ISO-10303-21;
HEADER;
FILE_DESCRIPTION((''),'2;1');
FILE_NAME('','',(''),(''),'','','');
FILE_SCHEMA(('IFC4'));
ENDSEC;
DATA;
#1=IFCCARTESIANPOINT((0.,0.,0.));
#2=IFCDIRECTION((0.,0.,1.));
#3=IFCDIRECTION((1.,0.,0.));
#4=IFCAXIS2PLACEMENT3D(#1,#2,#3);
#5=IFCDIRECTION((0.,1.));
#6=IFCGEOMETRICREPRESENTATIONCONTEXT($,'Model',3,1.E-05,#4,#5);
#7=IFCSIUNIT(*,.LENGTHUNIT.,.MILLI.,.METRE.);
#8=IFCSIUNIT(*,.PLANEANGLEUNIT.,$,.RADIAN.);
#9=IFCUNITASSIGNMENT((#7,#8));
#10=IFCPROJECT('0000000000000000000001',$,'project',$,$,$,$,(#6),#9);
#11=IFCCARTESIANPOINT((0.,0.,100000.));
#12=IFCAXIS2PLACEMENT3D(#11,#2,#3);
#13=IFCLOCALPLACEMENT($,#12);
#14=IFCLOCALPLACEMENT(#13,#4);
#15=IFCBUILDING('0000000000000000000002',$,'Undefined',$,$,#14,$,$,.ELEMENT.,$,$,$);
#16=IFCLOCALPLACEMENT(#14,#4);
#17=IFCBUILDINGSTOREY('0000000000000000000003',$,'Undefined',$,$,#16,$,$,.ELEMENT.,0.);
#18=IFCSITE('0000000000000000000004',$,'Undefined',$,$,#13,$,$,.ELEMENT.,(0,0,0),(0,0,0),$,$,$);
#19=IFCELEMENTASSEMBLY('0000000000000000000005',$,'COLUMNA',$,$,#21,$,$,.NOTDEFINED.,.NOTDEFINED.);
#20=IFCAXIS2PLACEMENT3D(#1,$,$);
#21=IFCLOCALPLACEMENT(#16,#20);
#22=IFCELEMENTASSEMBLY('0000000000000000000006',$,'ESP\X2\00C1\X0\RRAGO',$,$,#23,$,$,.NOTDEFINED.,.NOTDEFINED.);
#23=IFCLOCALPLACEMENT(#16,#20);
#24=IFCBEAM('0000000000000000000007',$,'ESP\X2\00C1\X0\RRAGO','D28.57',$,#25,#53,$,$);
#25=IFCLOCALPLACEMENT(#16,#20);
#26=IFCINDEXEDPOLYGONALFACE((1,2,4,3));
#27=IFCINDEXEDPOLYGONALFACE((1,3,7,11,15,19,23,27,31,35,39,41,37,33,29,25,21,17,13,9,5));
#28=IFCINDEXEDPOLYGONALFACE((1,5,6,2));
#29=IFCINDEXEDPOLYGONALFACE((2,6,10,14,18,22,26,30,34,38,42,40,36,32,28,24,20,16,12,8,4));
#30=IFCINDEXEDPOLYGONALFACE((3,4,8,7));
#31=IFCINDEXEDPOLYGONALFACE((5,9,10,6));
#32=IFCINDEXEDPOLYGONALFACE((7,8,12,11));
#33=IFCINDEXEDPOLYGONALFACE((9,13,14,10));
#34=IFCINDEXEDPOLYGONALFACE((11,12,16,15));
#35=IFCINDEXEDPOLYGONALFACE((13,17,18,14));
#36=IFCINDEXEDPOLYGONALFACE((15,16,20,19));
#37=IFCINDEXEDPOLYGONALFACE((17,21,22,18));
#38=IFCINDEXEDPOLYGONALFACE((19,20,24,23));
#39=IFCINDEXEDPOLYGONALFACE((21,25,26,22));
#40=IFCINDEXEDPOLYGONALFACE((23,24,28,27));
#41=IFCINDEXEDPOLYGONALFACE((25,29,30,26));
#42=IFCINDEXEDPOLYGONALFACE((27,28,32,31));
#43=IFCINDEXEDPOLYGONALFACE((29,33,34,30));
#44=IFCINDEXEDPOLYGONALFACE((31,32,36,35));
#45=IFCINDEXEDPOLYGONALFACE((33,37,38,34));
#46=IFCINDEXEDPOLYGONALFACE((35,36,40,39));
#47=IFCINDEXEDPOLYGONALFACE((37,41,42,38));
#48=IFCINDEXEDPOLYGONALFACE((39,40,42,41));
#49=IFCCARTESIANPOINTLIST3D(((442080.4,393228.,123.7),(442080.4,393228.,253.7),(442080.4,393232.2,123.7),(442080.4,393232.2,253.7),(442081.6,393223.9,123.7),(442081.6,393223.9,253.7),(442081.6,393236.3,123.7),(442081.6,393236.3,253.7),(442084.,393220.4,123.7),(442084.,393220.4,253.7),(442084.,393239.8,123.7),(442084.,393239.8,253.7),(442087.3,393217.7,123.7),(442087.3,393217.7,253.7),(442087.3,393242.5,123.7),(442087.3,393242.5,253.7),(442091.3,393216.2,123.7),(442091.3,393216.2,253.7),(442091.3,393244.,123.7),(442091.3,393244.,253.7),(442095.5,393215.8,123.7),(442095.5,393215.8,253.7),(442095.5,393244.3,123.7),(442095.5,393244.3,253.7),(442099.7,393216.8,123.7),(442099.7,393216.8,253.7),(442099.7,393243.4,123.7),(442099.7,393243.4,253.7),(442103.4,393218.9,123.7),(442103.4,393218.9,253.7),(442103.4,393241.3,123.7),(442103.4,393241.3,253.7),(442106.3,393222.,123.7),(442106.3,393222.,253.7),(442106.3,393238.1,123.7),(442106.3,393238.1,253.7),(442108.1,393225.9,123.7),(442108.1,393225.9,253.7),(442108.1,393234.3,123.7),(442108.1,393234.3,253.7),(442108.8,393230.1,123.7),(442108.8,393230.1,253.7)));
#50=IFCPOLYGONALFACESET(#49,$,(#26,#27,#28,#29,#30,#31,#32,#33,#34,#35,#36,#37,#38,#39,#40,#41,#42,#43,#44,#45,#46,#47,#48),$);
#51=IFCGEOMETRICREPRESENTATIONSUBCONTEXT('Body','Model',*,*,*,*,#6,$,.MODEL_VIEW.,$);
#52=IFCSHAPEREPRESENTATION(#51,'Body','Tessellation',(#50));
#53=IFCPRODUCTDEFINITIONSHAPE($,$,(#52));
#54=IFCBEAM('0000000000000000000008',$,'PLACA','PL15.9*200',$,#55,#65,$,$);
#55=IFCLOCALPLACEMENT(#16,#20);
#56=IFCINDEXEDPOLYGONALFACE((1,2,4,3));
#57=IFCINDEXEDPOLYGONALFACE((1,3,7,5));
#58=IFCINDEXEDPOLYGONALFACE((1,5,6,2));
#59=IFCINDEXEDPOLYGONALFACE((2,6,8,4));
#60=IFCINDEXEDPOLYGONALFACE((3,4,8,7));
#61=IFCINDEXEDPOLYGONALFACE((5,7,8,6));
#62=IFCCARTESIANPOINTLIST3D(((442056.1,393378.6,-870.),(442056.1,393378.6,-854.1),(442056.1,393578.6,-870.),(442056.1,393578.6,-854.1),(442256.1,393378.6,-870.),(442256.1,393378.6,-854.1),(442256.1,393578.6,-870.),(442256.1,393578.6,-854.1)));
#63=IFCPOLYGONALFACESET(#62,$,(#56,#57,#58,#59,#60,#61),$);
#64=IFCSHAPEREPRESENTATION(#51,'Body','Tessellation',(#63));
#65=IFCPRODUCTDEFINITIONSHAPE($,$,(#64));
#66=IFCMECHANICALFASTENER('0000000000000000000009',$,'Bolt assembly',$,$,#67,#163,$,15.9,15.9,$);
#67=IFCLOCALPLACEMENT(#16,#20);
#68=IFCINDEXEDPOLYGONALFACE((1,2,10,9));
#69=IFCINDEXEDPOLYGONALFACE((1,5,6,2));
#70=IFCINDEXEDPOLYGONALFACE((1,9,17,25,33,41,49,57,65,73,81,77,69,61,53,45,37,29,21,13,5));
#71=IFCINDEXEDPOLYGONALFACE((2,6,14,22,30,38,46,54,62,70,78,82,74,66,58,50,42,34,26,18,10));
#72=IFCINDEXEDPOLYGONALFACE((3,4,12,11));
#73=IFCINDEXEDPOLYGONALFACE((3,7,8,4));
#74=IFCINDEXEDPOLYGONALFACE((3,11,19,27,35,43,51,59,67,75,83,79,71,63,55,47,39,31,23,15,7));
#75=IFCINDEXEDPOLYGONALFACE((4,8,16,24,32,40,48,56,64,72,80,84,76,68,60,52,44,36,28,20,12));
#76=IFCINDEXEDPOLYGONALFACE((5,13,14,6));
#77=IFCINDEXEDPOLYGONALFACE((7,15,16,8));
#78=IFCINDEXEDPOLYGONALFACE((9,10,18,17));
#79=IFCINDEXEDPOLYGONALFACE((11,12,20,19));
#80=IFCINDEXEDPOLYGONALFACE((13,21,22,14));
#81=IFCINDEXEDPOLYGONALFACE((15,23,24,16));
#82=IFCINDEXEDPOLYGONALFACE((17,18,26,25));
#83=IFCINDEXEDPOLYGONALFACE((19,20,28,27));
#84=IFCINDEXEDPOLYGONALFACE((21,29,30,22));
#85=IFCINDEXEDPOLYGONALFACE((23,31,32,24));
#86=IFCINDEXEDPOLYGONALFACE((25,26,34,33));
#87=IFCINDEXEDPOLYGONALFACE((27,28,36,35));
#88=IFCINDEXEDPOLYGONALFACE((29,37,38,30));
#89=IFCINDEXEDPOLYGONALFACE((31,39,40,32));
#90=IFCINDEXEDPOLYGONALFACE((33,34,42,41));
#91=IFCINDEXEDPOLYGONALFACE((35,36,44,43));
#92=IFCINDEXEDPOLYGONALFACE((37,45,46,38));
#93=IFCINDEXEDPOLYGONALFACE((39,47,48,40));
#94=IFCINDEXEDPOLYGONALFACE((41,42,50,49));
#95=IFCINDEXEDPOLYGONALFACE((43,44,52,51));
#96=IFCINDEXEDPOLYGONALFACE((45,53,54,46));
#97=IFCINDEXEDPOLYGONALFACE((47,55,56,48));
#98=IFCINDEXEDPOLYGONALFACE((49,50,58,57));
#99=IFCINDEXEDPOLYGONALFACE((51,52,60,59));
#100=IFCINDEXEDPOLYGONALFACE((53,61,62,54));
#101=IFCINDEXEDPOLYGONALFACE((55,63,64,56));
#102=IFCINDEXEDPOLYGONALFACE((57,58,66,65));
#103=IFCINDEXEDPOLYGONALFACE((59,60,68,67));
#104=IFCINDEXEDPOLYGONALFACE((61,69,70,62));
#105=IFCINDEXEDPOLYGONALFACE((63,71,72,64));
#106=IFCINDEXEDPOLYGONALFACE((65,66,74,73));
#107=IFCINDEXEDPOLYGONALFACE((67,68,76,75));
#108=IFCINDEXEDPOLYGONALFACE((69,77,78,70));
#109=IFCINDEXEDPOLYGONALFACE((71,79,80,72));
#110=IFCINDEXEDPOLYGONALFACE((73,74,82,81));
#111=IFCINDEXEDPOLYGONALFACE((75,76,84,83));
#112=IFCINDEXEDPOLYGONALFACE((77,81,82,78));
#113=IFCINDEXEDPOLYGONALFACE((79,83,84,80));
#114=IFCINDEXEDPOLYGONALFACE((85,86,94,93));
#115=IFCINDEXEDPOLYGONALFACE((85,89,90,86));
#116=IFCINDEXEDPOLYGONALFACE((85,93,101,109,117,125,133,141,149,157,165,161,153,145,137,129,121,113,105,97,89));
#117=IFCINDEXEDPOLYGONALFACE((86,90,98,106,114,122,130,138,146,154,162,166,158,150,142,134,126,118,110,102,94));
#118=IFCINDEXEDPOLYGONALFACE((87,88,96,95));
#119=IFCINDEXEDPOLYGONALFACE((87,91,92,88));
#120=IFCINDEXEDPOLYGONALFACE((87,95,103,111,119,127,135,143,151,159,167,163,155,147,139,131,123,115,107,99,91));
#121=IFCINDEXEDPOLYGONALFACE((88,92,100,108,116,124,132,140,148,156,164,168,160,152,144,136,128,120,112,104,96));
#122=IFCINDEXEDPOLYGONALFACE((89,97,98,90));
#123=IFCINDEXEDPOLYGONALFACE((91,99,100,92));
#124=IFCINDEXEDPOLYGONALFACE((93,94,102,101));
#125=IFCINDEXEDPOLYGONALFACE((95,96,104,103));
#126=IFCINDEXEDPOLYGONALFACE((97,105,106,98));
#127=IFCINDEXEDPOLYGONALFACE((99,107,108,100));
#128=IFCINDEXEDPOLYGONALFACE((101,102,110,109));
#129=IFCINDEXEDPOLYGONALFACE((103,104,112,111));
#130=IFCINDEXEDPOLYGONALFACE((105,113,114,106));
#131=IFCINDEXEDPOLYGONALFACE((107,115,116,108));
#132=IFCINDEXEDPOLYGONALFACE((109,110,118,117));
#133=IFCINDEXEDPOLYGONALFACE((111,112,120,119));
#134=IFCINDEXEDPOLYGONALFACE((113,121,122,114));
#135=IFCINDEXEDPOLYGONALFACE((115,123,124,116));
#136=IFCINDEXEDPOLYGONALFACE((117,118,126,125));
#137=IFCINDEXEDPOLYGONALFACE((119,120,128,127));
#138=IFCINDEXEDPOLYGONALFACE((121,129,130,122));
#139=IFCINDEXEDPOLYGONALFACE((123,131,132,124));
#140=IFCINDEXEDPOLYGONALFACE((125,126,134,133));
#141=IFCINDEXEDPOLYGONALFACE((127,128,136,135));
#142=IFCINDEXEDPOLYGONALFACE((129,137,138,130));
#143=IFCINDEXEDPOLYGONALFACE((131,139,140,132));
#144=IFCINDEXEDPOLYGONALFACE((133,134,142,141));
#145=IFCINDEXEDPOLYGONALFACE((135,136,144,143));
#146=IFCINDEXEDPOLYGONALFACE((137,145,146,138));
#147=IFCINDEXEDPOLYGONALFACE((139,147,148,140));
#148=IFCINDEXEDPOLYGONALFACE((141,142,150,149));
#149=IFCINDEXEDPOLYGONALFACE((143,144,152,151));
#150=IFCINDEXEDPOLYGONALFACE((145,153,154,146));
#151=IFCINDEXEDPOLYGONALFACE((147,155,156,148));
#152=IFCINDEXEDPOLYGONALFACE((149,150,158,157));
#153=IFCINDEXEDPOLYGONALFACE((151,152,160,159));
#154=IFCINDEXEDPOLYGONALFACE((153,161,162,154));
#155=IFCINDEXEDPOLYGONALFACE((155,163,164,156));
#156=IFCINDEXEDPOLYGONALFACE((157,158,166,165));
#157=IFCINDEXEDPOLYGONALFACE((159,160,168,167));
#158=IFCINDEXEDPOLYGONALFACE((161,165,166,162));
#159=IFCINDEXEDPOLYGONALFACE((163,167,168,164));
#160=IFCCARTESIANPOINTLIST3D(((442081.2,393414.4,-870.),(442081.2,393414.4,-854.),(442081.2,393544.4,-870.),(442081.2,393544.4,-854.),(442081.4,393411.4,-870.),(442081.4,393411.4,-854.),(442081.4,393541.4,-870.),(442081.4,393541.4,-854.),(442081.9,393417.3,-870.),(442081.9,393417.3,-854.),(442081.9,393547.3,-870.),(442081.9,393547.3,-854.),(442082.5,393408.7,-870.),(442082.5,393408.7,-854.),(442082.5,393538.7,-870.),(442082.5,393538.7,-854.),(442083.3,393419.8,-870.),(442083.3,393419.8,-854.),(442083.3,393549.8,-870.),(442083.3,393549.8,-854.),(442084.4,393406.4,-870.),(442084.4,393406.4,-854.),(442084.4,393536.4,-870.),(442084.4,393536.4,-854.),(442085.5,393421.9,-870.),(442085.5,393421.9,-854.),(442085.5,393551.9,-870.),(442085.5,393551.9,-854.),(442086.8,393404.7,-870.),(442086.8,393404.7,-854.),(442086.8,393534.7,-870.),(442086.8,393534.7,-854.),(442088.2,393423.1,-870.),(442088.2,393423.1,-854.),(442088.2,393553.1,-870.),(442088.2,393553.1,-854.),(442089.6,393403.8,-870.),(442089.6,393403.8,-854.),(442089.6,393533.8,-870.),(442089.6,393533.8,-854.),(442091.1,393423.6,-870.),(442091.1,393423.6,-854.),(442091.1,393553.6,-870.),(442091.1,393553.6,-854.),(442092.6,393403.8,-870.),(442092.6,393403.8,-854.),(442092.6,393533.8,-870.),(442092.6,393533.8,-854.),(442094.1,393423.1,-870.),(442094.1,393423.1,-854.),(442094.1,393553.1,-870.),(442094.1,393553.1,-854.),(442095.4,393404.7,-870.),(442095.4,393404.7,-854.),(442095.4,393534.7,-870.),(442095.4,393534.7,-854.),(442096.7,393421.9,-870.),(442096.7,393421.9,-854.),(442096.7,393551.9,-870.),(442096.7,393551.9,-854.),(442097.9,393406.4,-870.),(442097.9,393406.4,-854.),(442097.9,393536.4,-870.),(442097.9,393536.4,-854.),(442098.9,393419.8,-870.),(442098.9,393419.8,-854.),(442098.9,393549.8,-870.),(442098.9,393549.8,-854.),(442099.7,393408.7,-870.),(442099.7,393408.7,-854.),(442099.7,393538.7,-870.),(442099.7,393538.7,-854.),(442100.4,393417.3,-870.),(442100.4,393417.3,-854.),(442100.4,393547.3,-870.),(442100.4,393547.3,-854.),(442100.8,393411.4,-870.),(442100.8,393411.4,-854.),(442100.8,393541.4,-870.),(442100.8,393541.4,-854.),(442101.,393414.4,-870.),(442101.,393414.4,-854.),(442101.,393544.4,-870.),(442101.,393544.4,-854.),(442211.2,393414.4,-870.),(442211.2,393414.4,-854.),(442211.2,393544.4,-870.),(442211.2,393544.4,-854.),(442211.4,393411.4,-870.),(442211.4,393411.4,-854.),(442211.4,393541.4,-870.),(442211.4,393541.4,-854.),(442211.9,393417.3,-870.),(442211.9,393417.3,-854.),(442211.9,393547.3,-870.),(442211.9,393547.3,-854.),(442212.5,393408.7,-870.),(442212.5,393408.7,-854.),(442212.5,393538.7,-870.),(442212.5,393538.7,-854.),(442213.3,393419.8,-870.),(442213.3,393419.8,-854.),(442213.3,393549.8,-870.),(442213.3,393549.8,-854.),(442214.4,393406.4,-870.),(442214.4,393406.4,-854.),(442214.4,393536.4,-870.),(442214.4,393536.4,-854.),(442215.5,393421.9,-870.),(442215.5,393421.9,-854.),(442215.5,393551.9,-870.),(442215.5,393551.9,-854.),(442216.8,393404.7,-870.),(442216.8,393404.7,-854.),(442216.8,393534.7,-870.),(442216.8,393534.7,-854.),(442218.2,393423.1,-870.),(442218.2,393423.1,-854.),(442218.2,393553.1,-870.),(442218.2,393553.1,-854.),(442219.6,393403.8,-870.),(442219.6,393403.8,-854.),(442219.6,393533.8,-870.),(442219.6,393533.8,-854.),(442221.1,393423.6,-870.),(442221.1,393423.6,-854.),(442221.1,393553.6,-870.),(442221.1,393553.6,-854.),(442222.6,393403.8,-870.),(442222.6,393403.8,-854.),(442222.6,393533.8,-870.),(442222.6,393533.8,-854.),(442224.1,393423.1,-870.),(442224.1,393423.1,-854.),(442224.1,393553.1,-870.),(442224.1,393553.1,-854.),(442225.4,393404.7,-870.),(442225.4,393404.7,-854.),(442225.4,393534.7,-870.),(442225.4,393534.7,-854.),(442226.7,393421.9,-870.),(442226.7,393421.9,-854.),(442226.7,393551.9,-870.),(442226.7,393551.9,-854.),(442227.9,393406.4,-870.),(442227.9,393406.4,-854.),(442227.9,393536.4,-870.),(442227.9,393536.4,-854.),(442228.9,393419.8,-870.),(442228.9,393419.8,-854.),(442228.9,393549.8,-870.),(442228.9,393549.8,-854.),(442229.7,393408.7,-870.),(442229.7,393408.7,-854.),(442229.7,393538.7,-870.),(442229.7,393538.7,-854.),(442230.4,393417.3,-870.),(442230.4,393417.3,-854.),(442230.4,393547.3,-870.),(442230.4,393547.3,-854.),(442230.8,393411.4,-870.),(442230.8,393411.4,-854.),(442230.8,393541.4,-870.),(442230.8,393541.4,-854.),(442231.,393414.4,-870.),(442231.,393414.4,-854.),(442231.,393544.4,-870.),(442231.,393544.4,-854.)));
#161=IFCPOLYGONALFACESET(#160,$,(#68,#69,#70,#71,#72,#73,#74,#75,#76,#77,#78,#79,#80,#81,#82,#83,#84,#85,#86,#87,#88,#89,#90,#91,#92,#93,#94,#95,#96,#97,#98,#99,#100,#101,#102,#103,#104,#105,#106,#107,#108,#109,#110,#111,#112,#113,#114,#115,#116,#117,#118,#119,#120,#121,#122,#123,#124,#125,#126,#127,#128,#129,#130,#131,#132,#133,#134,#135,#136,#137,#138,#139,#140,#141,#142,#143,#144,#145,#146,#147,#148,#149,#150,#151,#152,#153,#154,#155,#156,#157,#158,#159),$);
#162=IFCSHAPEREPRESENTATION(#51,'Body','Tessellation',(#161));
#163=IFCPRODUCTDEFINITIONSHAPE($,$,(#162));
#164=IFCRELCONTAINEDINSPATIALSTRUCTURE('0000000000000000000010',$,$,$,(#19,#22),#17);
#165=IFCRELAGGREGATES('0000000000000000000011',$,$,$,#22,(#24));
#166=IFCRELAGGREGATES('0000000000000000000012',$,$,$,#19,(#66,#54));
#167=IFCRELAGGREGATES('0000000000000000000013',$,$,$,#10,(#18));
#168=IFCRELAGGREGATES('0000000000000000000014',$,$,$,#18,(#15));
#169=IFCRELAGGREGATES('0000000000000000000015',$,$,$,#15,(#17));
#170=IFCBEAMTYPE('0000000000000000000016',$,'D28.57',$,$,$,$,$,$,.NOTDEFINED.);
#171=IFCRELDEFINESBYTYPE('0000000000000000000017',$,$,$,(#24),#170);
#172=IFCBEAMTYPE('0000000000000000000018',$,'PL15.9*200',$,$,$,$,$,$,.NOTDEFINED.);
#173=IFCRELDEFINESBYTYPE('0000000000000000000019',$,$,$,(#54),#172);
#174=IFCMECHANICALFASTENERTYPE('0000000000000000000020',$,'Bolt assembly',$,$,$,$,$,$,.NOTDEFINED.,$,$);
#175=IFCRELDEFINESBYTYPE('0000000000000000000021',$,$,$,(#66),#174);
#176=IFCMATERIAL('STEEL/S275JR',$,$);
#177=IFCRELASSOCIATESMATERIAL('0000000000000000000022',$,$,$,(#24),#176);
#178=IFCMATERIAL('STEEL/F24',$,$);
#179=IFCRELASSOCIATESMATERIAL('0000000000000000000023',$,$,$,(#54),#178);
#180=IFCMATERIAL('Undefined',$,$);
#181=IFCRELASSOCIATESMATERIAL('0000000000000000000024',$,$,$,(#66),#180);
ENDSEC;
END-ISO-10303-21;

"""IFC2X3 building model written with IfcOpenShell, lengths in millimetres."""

from ifc_helpers import new_model, si_unit, direction, frame, origin_with_axes, origin_2d_with_axis, place, context, subcontext, project, spatial, rectangle, circle, extrude, source, transform, mapped, material, type_object, element, aggregate, save


model = new_model("IFC2X3")

# Units and contexts
model_context = context("Model", 3, precision=1e-05, world=origin_with_axes(), true_north=direction((0.0, 1.0)))
body_context = subcontext(model_context, "Body", "Model", "MODEL_VIEW")
ifc_project = project(units=[si_unit("LENGTHUNIT", "METRE", prefix="MILLI"), si_unit("PLANEANGLEUNIT", "RADIAN")], contexts=[model_context])

# Site, building, storey
site_placement = place(None, frame((0.0, 0.0, 100000.0), z_axis=(0.0, 0.0, 1.0), x_axis=(1.0, 0.0, 0.0)))
site = spatial("IfcSite", under=ifc_project, at=site_placement, Name="Undefined", CompositionType="ELEMENT", RefLatitude=(0, 0, 0), RefLongitude=(0, 0, 0))
building_placement = place(site_placement, origin_with_axes())
building = spatial("IfcBuilding", under=site, at=building_placement, Name="Undefined", CompositionType="ELEMENT")
storey_placement = place(building_placement, origin_with_axes())
storey = spatial("IfcBuildingStorey", under=building, at=storey_placement, Name="Undefined", CompositionType="ELEMENT", Elevation=0.0)

# Shared definitions
ifc_material_1 = material(Name="STEEL/S275JR")

# Element assembly
assembly_1_placement = place(storey_placement, origin_with_axes())
assembly_1 = element("IfcElementAssembly", 1, at=assembly_1_placement, inside=storey, Name="COLUMNA", AssemblyPlace="NOTDEFINED", PredefinedType="NOTDEFINED")
ifc_material_2 = material(Name="STEEL/F24")

# Element assembly
assembly_2_placement = place(storey_placement, origin_with_axes())
assembly_2 = element("IfcElementAssembly", 2, at=assembly_2_placement, inside=storey, Name="ESPÁRRAGO", AssemblyPlace="NOTDEFINED", PredefinedType="NOTDEFINED")

# Beams
beam_type_1 = type_object("IfcBeamType", Name="D28.57", PredefinedType="NOTDEFINED")
beam_1_placement = place(assembly_2_placement, frame((442094.5, 393230.1, 253.7), z_axis=(0.866025, -0.5, 0.0), x_axis=(0.0, 0.0, -1.0)))
beam_1 = element("IfcBeam", 3, at=beam_1_placement, type_object=beam_type_1, material=ifc_material_1, Name="ESPÁRRAGO", Description="D28.57", context=body_context, shape_type="SweptSolid", body=[
    extrude(circle(Radius=14.3, at=origin_2d_with_axis()), frame((130.0, 0.0, 0.0), z_axis=(-1.0, 0.0, 0.0), x_axis=(0.0, -1.0, 0.0)), (0.0, 0.0, 1.0), 130.0),
])
aggregate(assembly_2, [beam_1])
beam_type_2 = type_object("IfcBeamType", Name="PL15.9*200", PredefinedType="NOTDEFINED")
beam_2_placement = place(assembly_1_placement, frame((442156.1, 393578.6, -862.1), z_axis=(1.0, 0.0, 0.0), x_axis=(0.0, -1.0, 0.0)))
beam_2 = element("IfcBeam", 4, at=beam_2_placement, type_object=beam_type_2, material=ifc_material_2, Name="PLACA", Description="PL15.9*200", context=body_context, shape_type="SweptSolid", body=[
    extrude(rectangle(XDim=15.9, YDim=200.0, at=origin_2d_with_axis()), frame((200.0, 0.0, 0.0), z_axis=(-1.0, 0.0, 0.0), x_axis=(0.0, -1.0, 0.0)), (0.0, 0.0, 1.0), 200.0),
])

# Mechanical fastener
ifc_material_3 = material(Name="Undefined")
mechanical_fastener_type = type_object("IfcMechanicalFastenerType", Name="Bolt assembly")
shared_shape = source(origin_with_axes(), body_context, "Body", "SweptSolid", [
    extrude(circle(Radius=9.9, at=origin_2d_with_axis()), frame((0.0, -15.9, 0.0), z_axis=(0.0, 1.0, 0.0), x_axis=(1.0, 0.0, 0.0)), (0.0, 0.0, 1.0), 16.0),
])
mechanical_fastener_placement = place(assembly_1_placement, frame((442156.1, 393418.6, -854.1), z_axis=(1.0, 0.0, 0.0), x_axis=(0.0, 1.0, 0.0)))
mechanical_fastener = element("IfcMechanicalFastener", 5, at=mechanical_fastener_placement, type_object=mechanical_fastener_type, material=ifc_material_3, Name="Bolt assembly", NominalDiameter=15.9, NominalLength=15.9, context=body_context, shape_type="MappedRepresentation", body=[
    mapped(shared_shape, transform((-5.0, 0.0, -65.0))),
    mapped(shared_shape, transform((-5.0, 0.0, 65.0))),
    mapped(shared_shape, transform((125.0, 0.0, -65.0))),
    mapped(shared_shape, transform((125.0, 0.0, 65.0))),
])
aggregate(assembly_1, [mechanical_fastener, beam_2])

save(model, "model.ifc")
